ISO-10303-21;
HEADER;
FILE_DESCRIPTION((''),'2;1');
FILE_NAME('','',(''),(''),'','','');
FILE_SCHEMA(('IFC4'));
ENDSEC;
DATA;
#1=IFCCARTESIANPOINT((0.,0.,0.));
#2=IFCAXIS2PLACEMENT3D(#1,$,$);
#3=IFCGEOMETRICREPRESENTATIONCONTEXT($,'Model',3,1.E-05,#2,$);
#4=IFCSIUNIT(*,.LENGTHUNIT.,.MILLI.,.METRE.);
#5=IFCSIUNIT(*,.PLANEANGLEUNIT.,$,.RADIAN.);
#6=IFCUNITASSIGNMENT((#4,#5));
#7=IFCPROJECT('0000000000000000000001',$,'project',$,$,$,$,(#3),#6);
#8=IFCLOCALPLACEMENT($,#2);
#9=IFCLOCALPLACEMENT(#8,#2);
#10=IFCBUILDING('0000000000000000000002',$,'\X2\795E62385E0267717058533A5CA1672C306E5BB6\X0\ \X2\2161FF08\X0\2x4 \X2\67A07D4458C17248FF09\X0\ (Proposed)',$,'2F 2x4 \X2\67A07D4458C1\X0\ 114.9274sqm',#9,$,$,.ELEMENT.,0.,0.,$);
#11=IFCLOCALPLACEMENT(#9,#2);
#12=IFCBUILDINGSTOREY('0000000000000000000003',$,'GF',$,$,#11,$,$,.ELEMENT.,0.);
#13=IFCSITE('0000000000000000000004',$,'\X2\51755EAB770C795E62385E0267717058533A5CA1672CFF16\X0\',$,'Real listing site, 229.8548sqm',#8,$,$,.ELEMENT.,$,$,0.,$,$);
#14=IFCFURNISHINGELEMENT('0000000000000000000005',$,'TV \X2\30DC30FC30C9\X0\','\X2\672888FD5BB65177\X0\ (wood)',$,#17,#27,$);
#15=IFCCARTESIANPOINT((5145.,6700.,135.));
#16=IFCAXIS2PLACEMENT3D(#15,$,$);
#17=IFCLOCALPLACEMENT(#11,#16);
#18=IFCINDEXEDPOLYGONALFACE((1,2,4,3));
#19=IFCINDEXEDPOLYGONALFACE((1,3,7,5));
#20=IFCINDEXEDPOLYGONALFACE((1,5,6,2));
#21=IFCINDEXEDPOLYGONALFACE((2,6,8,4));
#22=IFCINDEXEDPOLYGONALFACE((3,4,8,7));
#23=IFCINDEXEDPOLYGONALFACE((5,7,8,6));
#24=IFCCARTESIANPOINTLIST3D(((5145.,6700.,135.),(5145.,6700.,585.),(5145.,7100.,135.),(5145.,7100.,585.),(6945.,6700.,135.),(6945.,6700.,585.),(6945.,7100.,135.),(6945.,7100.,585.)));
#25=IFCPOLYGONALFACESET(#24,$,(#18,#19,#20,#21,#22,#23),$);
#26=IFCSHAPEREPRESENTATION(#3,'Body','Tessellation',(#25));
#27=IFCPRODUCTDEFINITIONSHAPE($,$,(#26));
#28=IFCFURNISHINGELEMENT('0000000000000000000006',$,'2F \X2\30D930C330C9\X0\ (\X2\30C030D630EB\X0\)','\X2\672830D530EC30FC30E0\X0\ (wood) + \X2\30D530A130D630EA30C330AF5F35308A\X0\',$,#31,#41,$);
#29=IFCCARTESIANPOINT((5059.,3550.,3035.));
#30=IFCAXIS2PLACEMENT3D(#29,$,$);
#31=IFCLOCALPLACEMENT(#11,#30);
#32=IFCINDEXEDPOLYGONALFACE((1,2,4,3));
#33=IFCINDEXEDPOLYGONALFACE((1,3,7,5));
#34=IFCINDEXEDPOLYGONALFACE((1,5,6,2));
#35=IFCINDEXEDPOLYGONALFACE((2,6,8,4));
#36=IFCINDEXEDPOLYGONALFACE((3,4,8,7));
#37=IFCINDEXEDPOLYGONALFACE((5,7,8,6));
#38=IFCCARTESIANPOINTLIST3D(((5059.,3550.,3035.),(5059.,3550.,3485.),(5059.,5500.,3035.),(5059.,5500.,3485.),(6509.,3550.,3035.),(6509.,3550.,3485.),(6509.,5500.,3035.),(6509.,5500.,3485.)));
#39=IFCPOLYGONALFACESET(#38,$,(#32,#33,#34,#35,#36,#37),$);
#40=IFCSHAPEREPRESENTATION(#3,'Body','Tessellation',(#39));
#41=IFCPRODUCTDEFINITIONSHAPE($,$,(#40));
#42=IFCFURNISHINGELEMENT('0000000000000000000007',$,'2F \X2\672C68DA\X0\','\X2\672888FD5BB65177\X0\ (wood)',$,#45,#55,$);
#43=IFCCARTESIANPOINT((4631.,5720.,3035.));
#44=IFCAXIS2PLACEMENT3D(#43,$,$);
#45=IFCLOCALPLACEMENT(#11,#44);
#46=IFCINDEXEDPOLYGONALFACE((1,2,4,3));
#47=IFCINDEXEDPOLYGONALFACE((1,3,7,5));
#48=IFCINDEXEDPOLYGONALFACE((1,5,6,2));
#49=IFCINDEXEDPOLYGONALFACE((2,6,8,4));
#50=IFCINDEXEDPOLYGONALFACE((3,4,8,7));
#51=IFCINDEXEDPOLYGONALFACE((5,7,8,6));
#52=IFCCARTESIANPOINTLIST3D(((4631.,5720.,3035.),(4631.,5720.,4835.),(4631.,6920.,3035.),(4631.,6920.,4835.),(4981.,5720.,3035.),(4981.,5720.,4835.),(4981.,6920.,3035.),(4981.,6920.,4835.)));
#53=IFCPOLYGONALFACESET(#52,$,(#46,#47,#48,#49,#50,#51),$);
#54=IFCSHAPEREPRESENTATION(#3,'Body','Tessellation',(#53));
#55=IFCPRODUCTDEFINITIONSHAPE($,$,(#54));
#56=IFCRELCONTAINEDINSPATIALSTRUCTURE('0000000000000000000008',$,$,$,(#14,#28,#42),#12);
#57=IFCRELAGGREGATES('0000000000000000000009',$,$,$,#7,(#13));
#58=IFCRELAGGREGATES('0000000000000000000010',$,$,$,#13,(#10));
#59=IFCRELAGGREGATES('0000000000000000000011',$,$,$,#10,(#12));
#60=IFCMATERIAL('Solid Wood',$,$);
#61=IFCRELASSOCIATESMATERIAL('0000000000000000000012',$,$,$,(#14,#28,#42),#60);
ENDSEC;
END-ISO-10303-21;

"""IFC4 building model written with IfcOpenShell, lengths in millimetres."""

from ifc_helpers import new_model, si_unit, frame, frame_2d, origin, place, context, project, spatial, rectangle, extrude, material, element, save


model = new_model("IFC4")

# Units and contexts
model_context = context("Model", 3, precision=1e-05, world=origin())
ifc_project = project(units=[si_unit("LENGTHUNIT", "METRE", prefix="MILLI"), si_unit("PLANEANGLEUNIT", "RADIAN")], contexts=[model_context])

# Site, building, storey
site_placement = place(None, origin())
site = spatial("IfcSite", under=ifc_project, at=site_placement, Name="兵庫県神戸市東灘区岡本６", ObjectType="Real listing site, 229.8548sqm", CompositionType="ELEMENT", RefElevation=0.0)
building_placement = place(site_placement, origin())
building = spatial("IfcBuilding", under=site, at=building_placement, Name="神戸市東灘区岡本の家 Ⅱ（2x4 枠組壁版） (Proposed)", ObjectType="2F 2x4 枠組壁 114.9274sqm", CompositionType="ELEMENT", ElevationOfRefHeight=0.0, ElevationOfTerrain=0.0)
storey_placement = place(building_placement, origin())
storey = spatial("IfcBuildingStorey", under=building, at=storey_placement, Name="GF", CompositionType="ELEMENT", Elevation=0.0)

# Shared definitions
ifc_material_1 = material(Name="Solid Wood")

# Furnishing elements
furnishing_1_placement = place(storey_placement, frame((5145.0, 6700.0, 135.0)))
element("IfcFurnishingElement", 1, at=furnishing_1_placement, inside=storey, material=ifc_material_1, Name="TV ボード", Description="木製家具 (wood)", context=model_context, shape_type="SweptSolid", body=[
    extrude(rectangle(XDim=1800.0, YDim=400.0, at=frame_2d((900.0, 200.0))), frame((5145.0, 6700.0, 135.0)), (0.0, 0.0, 1.0), 450.0),
])
furnishing_2_placement = place(storey_placement, frame((5059.0, 3550.0, 3035.0)))
element("IfcFurnishingElement", 2, at=furnishing_2_placement, inside=storey, material=ifc_material_1, Name="2F ベッド (ダブル)", Description="木フレーム (wood) + ファブリック張り", context=model_context, shape_type="SweptSolid", body=[
    extrude(rectangle(XDim=1450.0, YDim=1950.0, at=frame_2d((725.0, 975.0))), frame((5059.0, 3550.0, 3035.0)), (0.0, 0.0, 1.0), 450.0),
])
furnishing_3_placement = place(storey_placement, frame((4631.0, 5720.0, 3035.0)))
element("IfcFurnishingElement", 3, at=furnishing_3_placement, inside=storey, material=ifc_material_1, Name="2F 本棚", Description="木製家具 (wood)", context=model_context, shape_type="SweptSolid", body=[
    extrude(rectangle(XDim=350.0, YDim=1200.0, at=frame_2d((175.0, 600.0))), frame((4631.0, 5720.0, 3035.0)), (0.0, 0.0, 1.0), 1800.0),
])

save(model, "model.ifc")
